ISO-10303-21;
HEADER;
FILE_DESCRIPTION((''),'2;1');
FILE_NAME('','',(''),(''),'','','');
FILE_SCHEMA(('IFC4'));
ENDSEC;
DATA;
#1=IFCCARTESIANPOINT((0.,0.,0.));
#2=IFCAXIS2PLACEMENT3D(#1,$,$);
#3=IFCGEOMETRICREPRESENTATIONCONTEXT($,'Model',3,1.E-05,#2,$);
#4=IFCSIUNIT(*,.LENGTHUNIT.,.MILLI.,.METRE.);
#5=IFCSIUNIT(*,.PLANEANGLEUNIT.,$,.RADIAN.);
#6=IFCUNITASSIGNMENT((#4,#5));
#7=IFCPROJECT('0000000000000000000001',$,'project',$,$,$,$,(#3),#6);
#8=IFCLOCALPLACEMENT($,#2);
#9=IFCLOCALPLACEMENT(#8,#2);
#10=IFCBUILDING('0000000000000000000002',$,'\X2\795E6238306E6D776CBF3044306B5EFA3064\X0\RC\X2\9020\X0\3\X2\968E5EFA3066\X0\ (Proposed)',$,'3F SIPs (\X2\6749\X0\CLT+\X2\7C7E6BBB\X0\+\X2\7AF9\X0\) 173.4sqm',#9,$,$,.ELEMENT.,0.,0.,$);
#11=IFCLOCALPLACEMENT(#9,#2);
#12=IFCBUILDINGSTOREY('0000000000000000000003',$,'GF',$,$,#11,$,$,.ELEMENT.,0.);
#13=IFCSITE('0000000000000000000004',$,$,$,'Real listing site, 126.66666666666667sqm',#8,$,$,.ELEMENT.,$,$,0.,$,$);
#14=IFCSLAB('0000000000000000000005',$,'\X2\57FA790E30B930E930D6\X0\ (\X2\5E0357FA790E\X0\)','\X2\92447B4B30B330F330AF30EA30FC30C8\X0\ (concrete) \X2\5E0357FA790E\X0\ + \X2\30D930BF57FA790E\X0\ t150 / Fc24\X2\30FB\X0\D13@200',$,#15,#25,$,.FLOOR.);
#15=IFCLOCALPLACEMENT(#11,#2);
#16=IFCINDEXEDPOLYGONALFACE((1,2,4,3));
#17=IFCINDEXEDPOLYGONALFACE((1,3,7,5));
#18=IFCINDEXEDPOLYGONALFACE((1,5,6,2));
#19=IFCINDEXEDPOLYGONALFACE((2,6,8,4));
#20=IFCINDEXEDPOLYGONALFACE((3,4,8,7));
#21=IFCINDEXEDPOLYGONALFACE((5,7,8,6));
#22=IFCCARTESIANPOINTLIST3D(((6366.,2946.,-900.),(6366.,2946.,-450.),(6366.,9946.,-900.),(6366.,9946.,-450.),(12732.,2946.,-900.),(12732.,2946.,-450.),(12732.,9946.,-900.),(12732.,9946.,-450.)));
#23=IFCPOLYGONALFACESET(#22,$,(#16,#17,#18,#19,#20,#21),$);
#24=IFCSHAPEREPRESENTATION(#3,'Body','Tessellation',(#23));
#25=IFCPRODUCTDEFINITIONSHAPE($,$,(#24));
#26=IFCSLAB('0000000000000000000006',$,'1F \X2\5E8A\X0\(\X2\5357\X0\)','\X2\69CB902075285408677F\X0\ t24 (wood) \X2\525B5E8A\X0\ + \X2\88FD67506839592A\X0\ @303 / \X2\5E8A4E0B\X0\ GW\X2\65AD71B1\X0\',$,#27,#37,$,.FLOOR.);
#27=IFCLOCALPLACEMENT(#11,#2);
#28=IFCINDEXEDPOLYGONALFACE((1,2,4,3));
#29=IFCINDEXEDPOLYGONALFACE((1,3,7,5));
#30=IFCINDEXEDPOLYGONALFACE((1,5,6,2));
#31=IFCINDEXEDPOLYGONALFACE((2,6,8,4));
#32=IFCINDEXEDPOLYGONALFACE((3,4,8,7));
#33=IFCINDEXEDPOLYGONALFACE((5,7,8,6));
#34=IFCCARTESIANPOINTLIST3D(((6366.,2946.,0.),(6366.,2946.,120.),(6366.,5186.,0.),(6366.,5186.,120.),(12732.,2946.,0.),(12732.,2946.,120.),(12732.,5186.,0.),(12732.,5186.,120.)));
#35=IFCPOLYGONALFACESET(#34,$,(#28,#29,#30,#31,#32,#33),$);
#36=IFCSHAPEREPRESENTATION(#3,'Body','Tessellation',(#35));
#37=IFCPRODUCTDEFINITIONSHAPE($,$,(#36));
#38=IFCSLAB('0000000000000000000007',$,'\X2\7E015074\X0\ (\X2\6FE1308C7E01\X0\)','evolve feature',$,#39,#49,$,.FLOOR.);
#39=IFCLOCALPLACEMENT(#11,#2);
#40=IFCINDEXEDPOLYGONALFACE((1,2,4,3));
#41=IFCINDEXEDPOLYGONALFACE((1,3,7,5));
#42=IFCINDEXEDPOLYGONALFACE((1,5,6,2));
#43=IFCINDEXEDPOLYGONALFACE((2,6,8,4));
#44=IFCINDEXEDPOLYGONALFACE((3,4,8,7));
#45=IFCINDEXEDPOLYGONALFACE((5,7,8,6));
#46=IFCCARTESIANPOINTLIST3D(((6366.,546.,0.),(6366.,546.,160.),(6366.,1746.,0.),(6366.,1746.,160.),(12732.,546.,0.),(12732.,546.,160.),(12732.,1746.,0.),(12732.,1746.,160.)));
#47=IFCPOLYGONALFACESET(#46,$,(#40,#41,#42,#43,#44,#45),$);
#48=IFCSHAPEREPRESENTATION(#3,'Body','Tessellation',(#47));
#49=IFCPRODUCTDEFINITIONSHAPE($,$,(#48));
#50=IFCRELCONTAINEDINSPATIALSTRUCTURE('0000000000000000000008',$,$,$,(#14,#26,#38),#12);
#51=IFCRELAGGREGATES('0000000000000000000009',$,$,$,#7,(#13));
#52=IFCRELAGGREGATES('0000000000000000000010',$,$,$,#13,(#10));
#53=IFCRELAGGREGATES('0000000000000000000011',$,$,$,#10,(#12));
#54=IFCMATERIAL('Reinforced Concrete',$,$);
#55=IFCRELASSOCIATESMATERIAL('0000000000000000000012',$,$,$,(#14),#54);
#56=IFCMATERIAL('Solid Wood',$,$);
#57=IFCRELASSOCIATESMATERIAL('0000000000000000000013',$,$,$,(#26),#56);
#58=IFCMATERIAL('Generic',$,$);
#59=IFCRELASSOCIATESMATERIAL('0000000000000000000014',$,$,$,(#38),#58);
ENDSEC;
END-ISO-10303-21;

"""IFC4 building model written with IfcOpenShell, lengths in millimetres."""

from ifc_helpers import new_model, si_unit, frame, frame_2d, origin, place, context, project, spatial, rectangle, extrude, material, element, save


model = new_model("IFC4")

# Units and contexts
model_context = context("Model", 3, precision=1e-05, world=origin())
ifc_project = project(units=[si_unit("LENGTHUNIT", "METRE", prefix="MILLI"), si_unit("PLANEANGLEUNIT", "RADIAN")], contexts=[model_context])

# Site, building, storey
site_placement = place(None, origin())
site = spatial("IfcSite", under=ifc_project, at=site_placement, ObjectType="Real listing site, 126.66666666666667sqm", CompositionType="ELEMENT", RefElevation=0.0)
building_placement = place(site_placement, origin())
building = spatial("IfcBuilding", under=site, at=building_placement, Name="神戸の海沿いに建つRC造3階建て (Proposed)", ObjectType="3F SIPs (杉CLT+籾殻+竹) 173.4sqm", CompositionType="ELEMENT", ElevationOfRefHeight=0.0, ElevationOfTerrain=0.0)
storey_placement = place(building_placement, origin())
storey = spatial("IfcBuildingStorey", under=building, at=storey_placement, Name="GF", CompositionType="ELEMENT", Elevation=0.0)

# Slabs
ifc_material_1 = material(Name="Reinforced Concrete")
slab_1_placement = place(storey_placement, frame((3183.0, 1473.0, -450.0)))
element("IfcSlab", 1, at=slab_1_placement, inside=storey, material=ifc_material_1, Name="基礎スラブ (布基礎)", Description="鉄筋コンクリート (concrete) 布基礎 + ベタ基礎 t150 / Fc24・D13@200", PredefinedType="FLOOR", context=model_context, shape_type="SweptSolid", body=[
    extrude(rectangle(XDim=6366.0, YDim=7000.0, at=frame_2d((3183.0, 3500.0))), frame((3183.0, 1473.0, -450.0)), (0.0, 0.0, 1.0), 450.0),
])
ifc_material_2 = material(Name="Solid Wood")
slab_2_placement = place(storey_placement, frame((3183.0, 1473.0, 0.0)))
element("IfcSlab", 2, at=slab_2_placement, inside=storey, material=ifc_material_2, Name="1F 床(南)", Description="構造用合板 t24 (wood) 剛床 + 製材根太 @303 / 床下 GW断熱", PredefinedType="FLOOR", context=model_context, shape_type="SweptSolid", body=[
    extrude(rectangle(XDim=6366.0, YDim=2240.0, at=frame_2d((3183.0, 1120.0))), frame((3183.0, 1473.0, 0.0)), (0.0, 0.0, 1.0), 120.0),
])
ifc_material_3 = material(Name="Generic")
slab_3_placement = place(storey_placement, frame((3183.0, 273.0, 0.0)))
element("IfcSlab", 3, at=slab_3_placement, inside=storey, material=ifc_material_3, Name="縁側 (濡れ縁)", Description="evolve feature", PredefinedType="FLOOR", context=model_context, shape_type="SweptSolid", body=[
    extrude(rectangle(XDim=6366.0, YDim=1200.0, at=frame_2d((3183.0, 600.0))), frame((3183.0, 273.0, 0.0)), (0.0, 0.0, 1.0), 160.0),
])

save(model, "model.ifc")
